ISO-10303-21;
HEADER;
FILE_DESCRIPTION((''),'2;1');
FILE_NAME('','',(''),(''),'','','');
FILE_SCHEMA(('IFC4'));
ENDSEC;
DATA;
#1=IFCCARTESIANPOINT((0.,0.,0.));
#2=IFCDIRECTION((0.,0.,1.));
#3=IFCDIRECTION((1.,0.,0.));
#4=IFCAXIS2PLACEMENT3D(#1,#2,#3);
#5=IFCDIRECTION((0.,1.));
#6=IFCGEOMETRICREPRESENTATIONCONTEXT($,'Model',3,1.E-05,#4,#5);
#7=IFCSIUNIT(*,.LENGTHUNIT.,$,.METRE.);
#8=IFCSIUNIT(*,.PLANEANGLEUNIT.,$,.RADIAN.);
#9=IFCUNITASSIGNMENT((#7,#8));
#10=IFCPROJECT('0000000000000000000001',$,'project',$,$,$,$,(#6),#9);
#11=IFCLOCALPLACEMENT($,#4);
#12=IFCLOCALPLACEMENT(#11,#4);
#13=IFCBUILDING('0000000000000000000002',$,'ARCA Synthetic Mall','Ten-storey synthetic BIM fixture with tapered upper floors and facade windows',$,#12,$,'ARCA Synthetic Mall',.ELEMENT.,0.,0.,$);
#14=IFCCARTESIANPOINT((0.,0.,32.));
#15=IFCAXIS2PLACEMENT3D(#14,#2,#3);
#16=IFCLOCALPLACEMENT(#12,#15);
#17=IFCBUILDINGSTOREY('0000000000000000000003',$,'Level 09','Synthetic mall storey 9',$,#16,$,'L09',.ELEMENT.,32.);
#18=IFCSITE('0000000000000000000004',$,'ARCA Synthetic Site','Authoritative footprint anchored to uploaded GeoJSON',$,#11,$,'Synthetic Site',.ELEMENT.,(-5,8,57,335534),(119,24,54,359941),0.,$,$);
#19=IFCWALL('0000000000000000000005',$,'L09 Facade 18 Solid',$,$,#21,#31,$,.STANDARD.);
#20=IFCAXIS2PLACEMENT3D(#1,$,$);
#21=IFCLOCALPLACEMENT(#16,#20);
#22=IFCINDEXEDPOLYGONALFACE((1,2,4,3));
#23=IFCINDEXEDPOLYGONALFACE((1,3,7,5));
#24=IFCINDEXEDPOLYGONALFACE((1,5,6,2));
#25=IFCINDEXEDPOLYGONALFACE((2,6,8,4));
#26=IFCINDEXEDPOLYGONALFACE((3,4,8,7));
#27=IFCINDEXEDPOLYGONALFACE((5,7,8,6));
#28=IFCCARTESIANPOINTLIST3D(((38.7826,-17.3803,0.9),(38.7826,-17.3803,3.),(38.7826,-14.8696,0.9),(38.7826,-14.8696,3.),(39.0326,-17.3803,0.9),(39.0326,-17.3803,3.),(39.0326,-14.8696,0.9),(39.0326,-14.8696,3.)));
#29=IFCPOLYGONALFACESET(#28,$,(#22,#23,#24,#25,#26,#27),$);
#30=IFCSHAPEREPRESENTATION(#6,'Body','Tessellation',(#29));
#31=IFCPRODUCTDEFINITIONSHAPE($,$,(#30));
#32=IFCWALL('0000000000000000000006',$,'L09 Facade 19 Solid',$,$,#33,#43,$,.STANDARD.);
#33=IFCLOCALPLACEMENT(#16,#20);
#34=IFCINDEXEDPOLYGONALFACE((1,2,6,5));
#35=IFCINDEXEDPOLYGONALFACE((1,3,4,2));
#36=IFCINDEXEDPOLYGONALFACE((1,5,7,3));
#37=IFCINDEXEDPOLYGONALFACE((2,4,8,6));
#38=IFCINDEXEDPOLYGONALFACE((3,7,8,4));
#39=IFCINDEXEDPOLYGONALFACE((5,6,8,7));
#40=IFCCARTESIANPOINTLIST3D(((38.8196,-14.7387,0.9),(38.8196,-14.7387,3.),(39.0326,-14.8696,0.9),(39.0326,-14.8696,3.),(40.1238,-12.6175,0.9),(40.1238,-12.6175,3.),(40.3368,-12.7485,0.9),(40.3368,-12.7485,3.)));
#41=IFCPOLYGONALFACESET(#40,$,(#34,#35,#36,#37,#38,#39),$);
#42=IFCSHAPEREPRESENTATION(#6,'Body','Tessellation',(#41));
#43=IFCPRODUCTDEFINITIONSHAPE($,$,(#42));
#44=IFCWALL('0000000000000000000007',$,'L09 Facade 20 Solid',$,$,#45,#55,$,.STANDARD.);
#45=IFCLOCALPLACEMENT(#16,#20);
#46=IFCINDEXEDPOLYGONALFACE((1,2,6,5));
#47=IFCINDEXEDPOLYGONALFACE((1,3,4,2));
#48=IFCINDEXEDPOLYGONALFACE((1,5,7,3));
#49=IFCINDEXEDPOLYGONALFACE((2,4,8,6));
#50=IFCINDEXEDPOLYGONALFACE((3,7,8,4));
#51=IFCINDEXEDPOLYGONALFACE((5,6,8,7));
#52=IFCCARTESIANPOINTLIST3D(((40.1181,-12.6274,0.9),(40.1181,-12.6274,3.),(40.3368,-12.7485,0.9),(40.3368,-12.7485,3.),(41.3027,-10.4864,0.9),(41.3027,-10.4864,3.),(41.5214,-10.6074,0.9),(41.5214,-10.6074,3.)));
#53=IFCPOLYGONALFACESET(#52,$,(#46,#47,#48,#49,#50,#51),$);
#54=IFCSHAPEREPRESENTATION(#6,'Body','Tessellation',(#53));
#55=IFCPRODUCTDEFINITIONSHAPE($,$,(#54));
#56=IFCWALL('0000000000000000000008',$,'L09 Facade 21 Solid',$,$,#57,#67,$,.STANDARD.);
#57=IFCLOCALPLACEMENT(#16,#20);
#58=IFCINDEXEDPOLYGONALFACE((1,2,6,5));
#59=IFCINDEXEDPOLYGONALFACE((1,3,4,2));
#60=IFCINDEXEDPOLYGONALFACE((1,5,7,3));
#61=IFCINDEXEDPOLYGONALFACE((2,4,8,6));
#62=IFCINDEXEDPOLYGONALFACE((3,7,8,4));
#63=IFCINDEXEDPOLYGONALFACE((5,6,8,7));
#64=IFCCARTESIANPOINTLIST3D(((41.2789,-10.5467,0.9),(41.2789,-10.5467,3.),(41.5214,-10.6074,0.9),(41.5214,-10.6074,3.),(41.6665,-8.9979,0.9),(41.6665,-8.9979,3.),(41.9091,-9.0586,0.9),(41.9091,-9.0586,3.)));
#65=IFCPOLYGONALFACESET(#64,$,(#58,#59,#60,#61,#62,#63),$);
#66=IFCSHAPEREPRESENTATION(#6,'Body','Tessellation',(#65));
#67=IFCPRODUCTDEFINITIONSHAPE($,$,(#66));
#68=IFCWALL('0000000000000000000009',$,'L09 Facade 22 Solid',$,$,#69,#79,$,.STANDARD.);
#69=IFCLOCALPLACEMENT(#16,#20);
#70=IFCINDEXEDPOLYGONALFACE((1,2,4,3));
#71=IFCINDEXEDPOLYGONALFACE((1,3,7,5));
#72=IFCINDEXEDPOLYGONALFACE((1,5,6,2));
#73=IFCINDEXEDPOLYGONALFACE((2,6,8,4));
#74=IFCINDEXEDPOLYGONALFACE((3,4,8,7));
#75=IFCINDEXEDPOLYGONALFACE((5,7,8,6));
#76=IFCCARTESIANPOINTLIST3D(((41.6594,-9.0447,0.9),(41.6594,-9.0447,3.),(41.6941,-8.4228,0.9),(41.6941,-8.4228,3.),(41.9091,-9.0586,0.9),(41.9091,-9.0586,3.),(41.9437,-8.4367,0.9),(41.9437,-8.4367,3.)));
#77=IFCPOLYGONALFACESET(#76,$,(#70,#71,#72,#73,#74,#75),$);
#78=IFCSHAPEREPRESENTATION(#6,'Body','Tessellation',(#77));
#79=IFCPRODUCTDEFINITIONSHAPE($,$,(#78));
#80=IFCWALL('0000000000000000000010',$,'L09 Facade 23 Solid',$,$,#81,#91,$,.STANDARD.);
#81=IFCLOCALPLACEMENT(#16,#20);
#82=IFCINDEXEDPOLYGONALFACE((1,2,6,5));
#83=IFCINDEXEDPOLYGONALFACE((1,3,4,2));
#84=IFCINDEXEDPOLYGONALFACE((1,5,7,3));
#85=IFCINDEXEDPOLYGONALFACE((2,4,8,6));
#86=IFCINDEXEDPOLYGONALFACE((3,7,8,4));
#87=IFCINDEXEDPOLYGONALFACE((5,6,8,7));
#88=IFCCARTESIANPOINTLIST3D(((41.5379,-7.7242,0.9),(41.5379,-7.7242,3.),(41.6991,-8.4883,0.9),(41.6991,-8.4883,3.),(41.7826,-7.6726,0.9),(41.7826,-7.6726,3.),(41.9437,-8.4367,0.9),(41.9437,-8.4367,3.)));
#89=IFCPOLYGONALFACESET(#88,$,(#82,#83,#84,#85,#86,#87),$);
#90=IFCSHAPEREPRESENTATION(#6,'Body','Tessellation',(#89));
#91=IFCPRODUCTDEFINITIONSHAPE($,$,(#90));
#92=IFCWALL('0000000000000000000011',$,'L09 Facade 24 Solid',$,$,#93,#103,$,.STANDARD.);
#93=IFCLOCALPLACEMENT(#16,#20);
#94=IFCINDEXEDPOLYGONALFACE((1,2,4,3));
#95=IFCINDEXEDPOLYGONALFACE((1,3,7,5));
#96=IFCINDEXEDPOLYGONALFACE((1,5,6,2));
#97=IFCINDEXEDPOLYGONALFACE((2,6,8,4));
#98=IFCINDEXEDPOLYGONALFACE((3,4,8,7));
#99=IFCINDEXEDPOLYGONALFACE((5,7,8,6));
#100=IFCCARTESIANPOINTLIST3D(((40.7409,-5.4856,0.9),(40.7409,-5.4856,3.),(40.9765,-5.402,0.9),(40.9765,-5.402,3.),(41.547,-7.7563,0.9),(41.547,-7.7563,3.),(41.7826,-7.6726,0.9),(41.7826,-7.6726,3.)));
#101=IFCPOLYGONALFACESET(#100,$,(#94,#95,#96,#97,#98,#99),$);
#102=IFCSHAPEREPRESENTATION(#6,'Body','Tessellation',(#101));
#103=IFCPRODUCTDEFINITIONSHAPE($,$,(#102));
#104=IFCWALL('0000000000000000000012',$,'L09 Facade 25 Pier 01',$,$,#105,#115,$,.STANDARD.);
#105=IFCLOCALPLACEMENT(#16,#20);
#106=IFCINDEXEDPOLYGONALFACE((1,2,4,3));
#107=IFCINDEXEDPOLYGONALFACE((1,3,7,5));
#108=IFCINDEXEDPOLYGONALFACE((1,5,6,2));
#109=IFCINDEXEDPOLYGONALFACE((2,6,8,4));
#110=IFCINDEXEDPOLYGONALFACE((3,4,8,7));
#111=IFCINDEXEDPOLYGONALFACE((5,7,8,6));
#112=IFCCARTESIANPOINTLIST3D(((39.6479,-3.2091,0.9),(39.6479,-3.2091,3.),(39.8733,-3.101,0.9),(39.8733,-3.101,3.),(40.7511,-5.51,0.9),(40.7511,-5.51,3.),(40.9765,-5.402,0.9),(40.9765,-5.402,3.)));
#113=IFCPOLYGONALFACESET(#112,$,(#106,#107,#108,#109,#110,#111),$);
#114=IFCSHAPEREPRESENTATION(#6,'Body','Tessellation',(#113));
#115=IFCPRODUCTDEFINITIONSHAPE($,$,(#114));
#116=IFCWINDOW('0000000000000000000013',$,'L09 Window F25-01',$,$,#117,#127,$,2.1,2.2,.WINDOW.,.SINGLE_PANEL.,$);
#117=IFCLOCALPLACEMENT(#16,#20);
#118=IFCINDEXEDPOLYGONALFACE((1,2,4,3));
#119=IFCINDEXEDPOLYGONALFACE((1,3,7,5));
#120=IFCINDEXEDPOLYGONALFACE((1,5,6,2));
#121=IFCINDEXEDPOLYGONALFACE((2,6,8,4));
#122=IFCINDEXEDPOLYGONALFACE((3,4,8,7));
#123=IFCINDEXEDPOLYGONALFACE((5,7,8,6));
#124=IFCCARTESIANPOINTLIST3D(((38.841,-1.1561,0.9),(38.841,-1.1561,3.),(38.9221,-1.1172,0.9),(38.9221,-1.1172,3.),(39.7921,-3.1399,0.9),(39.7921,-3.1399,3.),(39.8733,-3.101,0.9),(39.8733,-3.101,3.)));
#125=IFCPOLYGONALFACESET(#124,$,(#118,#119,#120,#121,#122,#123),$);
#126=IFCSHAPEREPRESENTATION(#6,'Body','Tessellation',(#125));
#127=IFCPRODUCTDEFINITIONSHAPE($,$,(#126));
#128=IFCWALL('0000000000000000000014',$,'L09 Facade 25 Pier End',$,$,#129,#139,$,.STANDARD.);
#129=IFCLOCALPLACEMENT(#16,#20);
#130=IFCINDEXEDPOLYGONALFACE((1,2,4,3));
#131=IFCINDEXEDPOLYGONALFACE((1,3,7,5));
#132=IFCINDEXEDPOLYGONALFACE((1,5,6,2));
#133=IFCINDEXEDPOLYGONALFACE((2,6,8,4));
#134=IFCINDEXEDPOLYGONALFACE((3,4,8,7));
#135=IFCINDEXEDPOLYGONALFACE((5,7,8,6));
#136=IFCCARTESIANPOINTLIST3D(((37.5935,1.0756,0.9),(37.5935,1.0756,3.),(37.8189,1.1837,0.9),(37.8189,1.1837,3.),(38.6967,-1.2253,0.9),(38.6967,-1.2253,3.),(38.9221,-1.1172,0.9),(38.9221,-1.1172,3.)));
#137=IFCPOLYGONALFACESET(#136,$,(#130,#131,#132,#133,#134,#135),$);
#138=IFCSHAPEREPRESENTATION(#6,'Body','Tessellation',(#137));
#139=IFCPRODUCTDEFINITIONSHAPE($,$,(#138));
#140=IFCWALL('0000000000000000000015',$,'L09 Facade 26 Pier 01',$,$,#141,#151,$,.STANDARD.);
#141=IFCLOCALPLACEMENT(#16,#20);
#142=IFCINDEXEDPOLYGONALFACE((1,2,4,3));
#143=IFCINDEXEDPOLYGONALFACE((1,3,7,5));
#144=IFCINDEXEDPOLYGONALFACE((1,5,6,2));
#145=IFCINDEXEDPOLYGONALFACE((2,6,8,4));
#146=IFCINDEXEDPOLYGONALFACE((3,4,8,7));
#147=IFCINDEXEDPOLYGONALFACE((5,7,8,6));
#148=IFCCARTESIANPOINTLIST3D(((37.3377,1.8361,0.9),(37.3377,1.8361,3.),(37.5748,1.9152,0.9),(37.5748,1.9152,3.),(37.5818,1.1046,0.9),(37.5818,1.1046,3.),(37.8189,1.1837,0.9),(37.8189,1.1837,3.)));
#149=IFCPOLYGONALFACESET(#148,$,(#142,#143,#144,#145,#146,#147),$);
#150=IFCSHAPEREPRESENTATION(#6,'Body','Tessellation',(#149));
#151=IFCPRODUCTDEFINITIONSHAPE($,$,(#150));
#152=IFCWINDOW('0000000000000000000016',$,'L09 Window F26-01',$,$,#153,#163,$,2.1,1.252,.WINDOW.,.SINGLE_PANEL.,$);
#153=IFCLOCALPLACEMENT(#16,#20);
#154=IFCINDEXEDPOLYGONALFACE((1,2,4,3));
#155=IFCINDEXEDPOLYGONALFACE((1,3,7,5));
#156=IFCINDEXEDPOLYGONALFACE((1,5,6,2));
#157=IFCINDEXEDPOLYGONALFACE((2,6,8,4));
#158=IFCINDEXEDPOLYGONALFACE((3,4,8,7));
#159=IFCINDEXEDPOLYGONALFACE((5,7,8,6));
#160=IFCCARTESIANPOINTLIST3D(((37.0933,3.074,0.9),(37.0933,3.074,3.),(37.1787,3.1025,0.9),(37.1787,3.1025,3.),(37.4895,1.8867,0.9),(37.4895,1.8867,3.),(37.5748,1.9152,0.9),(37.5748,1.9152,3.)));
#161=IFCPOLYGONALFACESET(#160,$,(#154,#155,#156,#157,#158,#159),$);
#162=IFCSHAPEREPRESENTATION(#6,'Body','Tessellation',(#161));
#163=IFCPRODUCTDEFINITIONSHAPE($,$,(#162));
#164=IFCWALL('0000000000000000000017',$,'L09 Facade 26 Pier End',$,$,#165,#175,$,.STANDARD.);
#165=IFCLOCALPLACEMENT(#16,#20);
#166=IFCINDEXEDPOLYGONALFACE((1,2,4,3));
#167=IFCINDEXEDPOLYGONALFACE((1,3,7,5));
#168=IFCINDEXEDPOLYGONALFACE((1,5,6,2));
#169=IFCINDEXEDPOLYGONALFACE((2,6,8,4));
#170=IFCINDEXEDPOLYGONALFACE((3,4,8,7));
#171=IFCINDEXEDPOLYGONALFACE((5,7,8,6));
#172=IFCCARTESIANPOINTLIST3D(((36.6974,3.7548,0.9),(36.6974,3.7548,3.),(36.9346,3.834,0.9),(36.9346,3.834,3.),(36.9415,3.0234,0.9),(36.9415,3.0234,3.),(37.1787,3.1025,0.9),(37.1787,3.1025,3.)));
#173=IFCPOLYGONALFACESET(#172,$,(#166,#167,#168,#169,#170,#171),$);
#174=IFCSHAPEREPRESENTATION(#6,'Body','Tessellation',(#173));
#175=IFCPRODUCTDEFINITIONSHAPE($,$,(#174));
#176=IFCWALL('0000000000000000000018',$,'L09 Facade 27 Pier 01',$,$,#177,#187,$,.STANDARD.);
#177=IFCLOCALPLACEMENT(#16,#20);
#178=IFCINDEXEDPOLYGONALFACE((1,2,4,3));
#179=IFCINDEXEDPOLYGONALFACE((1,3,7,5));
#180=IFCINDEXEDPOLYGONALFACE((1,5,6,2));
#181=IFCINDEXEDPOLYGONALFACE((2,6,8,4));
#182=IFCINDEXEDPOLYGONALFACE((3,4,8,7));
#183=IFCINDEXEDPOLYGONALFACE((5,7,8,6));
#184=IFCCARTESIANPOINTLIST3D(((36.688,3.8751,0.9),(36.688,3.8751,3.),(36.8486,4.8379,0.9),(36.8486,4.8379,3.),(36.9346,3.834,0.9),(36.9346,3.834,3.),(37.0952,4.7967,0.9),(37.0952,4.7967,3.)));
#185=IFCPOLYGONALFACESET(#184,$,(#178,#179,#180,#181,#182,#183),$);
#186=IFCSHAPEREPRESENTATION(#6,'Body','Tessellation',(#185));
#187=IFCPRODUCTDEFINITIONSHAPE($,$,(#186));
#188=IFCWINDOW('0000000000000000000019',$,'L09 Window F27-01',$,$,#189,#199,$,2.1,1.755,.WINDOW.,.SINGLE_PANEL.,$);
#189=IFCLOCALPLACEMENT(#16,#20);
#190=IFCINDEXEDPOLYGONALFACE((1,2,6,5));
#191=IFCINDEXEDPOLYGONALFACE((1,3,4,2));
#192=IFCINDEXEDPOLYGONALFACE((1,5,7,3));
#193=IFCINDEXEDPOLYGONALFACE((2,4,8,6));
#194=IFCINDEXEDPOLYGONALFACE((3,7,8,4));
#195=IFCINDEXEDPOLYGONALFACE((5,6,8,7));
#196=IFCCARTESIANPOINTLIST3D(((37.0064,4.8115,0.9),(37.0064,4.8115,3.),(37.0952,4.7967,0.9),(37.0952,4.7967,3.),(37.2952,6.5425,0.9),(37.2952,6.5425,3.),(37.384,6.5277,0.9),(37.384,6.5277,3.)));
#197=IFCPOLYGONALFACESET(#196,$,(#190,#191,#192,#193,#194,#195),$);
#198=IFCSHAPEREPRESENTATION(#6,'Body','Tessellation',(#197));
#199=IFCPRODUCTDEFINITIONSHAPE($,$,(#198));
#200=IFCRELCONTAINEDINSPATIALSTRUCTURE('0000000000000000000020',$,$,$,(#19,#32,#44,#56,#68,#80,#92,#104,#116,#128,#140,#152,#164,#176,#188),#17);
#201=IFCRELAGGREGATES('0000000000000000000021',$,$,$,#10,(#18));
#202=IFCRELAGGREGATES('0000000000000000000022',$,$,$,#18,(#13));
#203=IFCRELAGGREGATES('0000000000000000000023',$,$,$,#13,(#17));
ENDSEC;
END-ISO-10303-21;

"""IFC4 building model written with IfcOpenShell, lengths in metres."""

from ifc_helpers import new_model, si_unit, direction, frame, origin_with_axes, place, context, project, spatial, polyline, outline, extrude, element, save


model = new_model("IFC4")

# Units and contexts
model_context = context("Model", 3, precision=1e-05, world=origin_with_axes(), true_north=direction((0.0, 1.0)))
ifc_project = project(units=[si_unit("LENGTHUNIT", "METRE"), si_unit("PLANEANGLEUNIT", "RADIAN")], contexts=[model_context])

# Site, building, storey
site_placement = place(None, origin_with_axes())
site = spatial("IfcSite", under=ifc_project, at=site_placement, Name="ARCA Synthetic Site", Description="Authoritative footprint anchored to uploaded GeoJSON", LongName="Synthetic Site", CompositionType="ELEMENT", RefLatitude=(-5, 8, 57, 335534), RefLongitude=(119, 24, 54, 359941), RefElevation=0.0)
building_placement = place(site_placement, origin_with_axes())
building = spatial("IfcBuilding", under=site, at=building_placement, Name="ARCA Synthetic Mall", Description="Ten-storey synthetic BIM fixture with tapered upper floors and facade windows", LongName="ARCA Synthetic Mall", CompositionType="ELEMENT", ElevationOfRefHeight=0.0, ElevationOfTerrain=0.0)
storey_placement = place(building_placement, frame((0.0, 0.0, 32.0), z_axis=(0.0, 0.0, 1.0), x_axis=(1.0, 0.0, 0.0)))
storey = spatial("IfcBuildingStorey", under=building, at=storey_placement, Name="Level 09", Description="Synthetic mall storey 9", LongName="L09", CompositionType="ELEMENT", Elevation=32.0)

# Walls
wall_1_placement = place(storey_placement, frame((0.0, 0.0, 0.9), z_axis=(0.0, 0.0, 1.0), x_axis=(1.0, 0.0, 0.0)))
element("IfcWall", 1, at=wall_1_placement, inside=storey, Name="L09 Facade 18 Solid", PredefinedType="STANDARD", context=model_context, shape_type="SweptSolid", body=[
    extrude(outline(polyline([(39.0326, -17.3803), (39.0326, -14.8696), (38.7826, -14.8696), (38.7826, -17.3803), (39.0326, -17.3803)])), origin_with_axes(), (0.0, 0.0, 1.0), 2.1),
])
wall_2_placement = place(storey_placement, frame((0.0, 0.0, 0.9), z_axis=(0.0, 0.0, 1.0), x_axis=(1.0, 0.0, 0.0)))
element("IfcWall", 2, at=wall_2_placement, inside=storey, Name="L09 Facade 19 Solid", PredefinedType="STANDARD", context=model_context, shape_type="SweptSolid", body=[
    extrude(outline(polyline([(39.0326, -14.8696), (40.3368, -12.7485), (40.1238, -12.6175), (38.8196, -14.7387), (39.0326, -14.8696)])), origin_with_axes(), (0.0, 0.0, 1.0), 2.1),
])
wall_3_placement = place(storey_placement, frame((0.0, 0.0, 0.9), z_axis=(0.0, 0.0, 1.0), x_axis=(1.0, 0.0, 0.0)))
element("IfcWall", 3, at=wall_3_placement, inside=storey, Name="L09 Facade 20 Solid", PredefinedType="STANDARD", context=model_context, shape_type="SweptSolid", body=[
    extrude(outline(polyline([(40.3368, -12.7485), (41.5214, -10.6074), (41.3027, -10.4864), (40.1181, -12.6274), (40.3368, -12.7485)])), origin_with_axes(), (0.0, 0.0, 1.0), 2.1),
])
wall_4_placement = place(storey_placement, frame((0.0, 0.0, 0.9), z_axis=(0.0, 0.0, 1.0), x_axis=(1.0, 0.0, 0.0)))
element("IfcWall", 4, at=wall_4_placement, inside=storey, Name="L09 Facade 21 Solid", PredefinedType="STANDARD", context=model_context, shape_type="SweptSolid", body=[
    extrude(outline(polyline([(41.5214, -10.6074), (41.9091, -9.0586), (41.6665, -8.9979), (41.2789, -10.5467), (41.5214, -10.6074)])), origin_with_axes(), (0.0, 0.0, 1.0), 2.1),
])
wall_5_placement = place(storey_placement, frame((0.0, 0.0, 0.9), z_axis=(0.0, 0.0, 1.0), x_axis=(1.0, 0.0, 0.0)))
element("IfcWall", 5, at=wall_5_placement, inside=storey, Name="L09 Facade 22 Solid", PredefinedType="STANDARD", context=model_context, shape_type="SweptSolid", body=[
    extrude(outline(polyline([(41.9091, -9.0586), (41.9437, -8.4367), (41.6941, -8.4228), (41.6594, -9.0447), (41.9091, -9.0586)])), origin_with_axes(), (0.0, 0.0, 1.0), 2.1),
])
wall_6_placement = place(storey_placement, frame((0.0, 0.0, 0.9), z_axis=(0.0, 0.0, 1.0), x_axis=(1.0, 0.0, 0.0)))
element("IfcWall", 6, at=wall_6_placement, inside=storey, Name="L09 Facade 23 Solid", PredefinedType="STANDARD", context=model_context, shape_type="SweptSolid", body=[
    extrude(outline(polyline([(41.9437, -8.4367), (41.7826, -7.6726), (41.5379, -7.7242), (41.6991, -8.4883), (41.9437, -8.4367)])), origin_with_axes(), (0.0, 0.0, 1.0), 2.1),
])
wall_7_placement = place(storey_placement, frame((0.0, 0.0, 0.9), z_axis=(0.0, 0.0, 1.0), x_axis=(1.0, 0.0, 0.0)))
element("IfcWall", 7, at=wall_7_placement, inside=storey, Name="L09 Facade 24 Solid", PredefinedType="STANDARD", context=model_context, shape_type="SweptSolid", body=[
    extrude(outline(polyline([(41.7826, -7.6726), (40.9765, -5.402), (40.7409, -5.4856), (41.547, -7.7563), (41.7826, -7.6726)])), origin_with_axes(), (0.0, 0.0, 1.0), 2.1),
])
wall_8_placement = place(storey_placement, frame((0.0, 0.0, 0.9), z_axis=(0.0, 0.0, 1.0), x_axis=(1.0, 0.0, 0.0)))
element("IfcWall", 8, at=wall_8_placement, inside=storey, Name="L09 Facade 25 Pier 01", PredefinedType="STANDARD", context=model_context, shape_type="SweptSolid", body=[
    extrude(outline(polyline([(40.9765, -5.402), (39.8733, -3.101), (39.6479, -3.2091), (40.7511, -5.51), (40.9765, -5.402)])), origin_with_axes(), (0.0, 0.0, 1.0), 2.1),
])

# Window
window_1_placement = place(storey_placement, frame((0.0, 0.0, 0.9), z_axis=(0.0, 0.0, 1.0), x_axis=(1.0, 0.0, 0.0)))
element("IfcWindow", 9, at=window_1_placement, inside=storey, Name="L09 Window F25-01", OverallHeight=2.1, OverallWidth=2.2, PartitioningType="SINGLE_PANEL", PredefinedType="WINDOW", context=model_context, shape_type="SweptSolid", body=[
    extrude(outline(polyline([(39.8733, -3.101), (38.9221, -1.1172), (38.841, -1.1561), (39.7921, -3.1399), (39.8733, -3.101)])), origin_with_axes(), (0.0, 0.0, 1.0), 2.1),
])

# Walls
wall_9_placement = place(storey_placement, frame((0.0, 0.0, 0.9), z_axis=(0.0, 0.0, 1.0), x_axis=(1.0, 0.0, 0.0)))
element("IfcWall", 10, at=wall_9_placement, inside=storey, Name="L09 Facade 25 Pier End", PredefinedType="STANDARD", context=model_context, shape_type="SweptSolid", body=[
    extrude(outline(polyline([(38.9221, -1.1172), (37.8189, 1.1837), (37.5935, 1.0756), (38.6967, -1.2253), (38.9221, -1.1172)])), origin_with_axes(), (0.0, 0.0, 1.0), 2.1),
])
wall_10_placement = place(storey_placement, frame((0.0, 0.0, 0.9), z_axis=(0.0, 0.0, 1.0), x_axis=(1.0, 0.0, 0.0)))
element("IfcWall", 11, at=wall_10_placement, inside=storey, Name="L09 Facade 26 Pier 01", PredefinedType="STANDARD", context=model_context, shape_type="SweptSolid", body=[
    extrude(outline(polyline([(37.8189, 1.1837), (37.5748, 1.9152), (37.3377, 1.8361), (37.5818, 1.1046), (37.8189, 1.1837)])), origin_with_axes(), (0.0, 0.0, 1.0), 2.1),
])

# Window
window_2_placement = place(storey_placement, frame((0.0, 0.0, 0.9), z_axis=(0.0, 0.0, 1.0), x_axis=(1.0, 0.0, 0.0)))
element("IfcWindow", 12, at=window_2_placement, inside=storey, Name="L09 Window F26-01", OverallHeight=2.1, OverallWidth=1.252, PartitioningType="SINGLE_PANEL", PredefinedType="WINDOW", context=model_context, shape_type="SweptSolid", body=[
    extrude(outline(polyline([(37.5748, 1.9152), (37.1787, 3.1025), (37.0933, 3.074), (37.4895, 1.8867), (37.5748, 1.9152)])), origin_with_axes(), (0.0, 0.0, 1.0), 2.1),
])

# Walls
wall_11_placement = place(storey_placement, frame((0.0, 0.0, 0.9), z_axis=(0.0, 0.0, 1.0), x_axis=(1.0, 0.0, 0.0)))
element("IfcWall", 13, at=wall_11_placement, inside=storey, Name="L09 Facade 26 Pier End", PredefinedType="STANDARD", context=model_context, shape_type="SweptSolid", body=[
    extrude(outline(polyline([(37.1787, 3.1025), (36.9346, 3.834), (36.6974, 3.7548), (36.9415, 3.0234), (37.1787, 3.1025)])), origin_with_axes(), (0.0, 0.0, 1.0), 2.1),
])
wall_12_placement = place(storey_placement, frame((0.0, 0.0, 0.9), z_axis=(0.0, 0.0, 1.0), x_axis=(1.0, 0.0, 0.0)))
element("IfcWall", 14, at=wall_12_placement, inside=storey, Name="L09 Facade 27 Pier 01", PredefinedType="STANDARD", context=model_context, shape_type="SweptSolid", body=[
    extrude(outline(polyline([(36.9346, 3.834), (37.0952, 4.7967), (36.8486, 4.8379), (36.688, 3.8751), (36.9346, 3.834)])), origin_with_axes(), (0.0, 0.0, 1.0), 2.1),
])

# Window
window_3_placement = place(storey_placement, frame((0.0, 0.0, 0.9), z_axis=(0.0, 0.0, 1.0), x_axis=(1.0, 0.0, 0.0)))
element("IfcWindow", 15, at=window_3_placement, inside=storey, Name="L09 Window F27-01", OverallHeight=2.1, OverallWidth=1.755, PartitioningType="SINGLE_PANEL", PredefinedType="WINDOW", context=model_context, shape_type="SweptSolid", body=[
    extrude(outline(polyline([(37.0952, 4.7967), (37.384, 6.5277), (37.2952, 6.5425), (37.0064, 4.8115), (37.0952, 4.7967)])), origin_with_axes(), (0.0, 0.0, 1.0), 2.1),
])

save(model, "model.ifc")
